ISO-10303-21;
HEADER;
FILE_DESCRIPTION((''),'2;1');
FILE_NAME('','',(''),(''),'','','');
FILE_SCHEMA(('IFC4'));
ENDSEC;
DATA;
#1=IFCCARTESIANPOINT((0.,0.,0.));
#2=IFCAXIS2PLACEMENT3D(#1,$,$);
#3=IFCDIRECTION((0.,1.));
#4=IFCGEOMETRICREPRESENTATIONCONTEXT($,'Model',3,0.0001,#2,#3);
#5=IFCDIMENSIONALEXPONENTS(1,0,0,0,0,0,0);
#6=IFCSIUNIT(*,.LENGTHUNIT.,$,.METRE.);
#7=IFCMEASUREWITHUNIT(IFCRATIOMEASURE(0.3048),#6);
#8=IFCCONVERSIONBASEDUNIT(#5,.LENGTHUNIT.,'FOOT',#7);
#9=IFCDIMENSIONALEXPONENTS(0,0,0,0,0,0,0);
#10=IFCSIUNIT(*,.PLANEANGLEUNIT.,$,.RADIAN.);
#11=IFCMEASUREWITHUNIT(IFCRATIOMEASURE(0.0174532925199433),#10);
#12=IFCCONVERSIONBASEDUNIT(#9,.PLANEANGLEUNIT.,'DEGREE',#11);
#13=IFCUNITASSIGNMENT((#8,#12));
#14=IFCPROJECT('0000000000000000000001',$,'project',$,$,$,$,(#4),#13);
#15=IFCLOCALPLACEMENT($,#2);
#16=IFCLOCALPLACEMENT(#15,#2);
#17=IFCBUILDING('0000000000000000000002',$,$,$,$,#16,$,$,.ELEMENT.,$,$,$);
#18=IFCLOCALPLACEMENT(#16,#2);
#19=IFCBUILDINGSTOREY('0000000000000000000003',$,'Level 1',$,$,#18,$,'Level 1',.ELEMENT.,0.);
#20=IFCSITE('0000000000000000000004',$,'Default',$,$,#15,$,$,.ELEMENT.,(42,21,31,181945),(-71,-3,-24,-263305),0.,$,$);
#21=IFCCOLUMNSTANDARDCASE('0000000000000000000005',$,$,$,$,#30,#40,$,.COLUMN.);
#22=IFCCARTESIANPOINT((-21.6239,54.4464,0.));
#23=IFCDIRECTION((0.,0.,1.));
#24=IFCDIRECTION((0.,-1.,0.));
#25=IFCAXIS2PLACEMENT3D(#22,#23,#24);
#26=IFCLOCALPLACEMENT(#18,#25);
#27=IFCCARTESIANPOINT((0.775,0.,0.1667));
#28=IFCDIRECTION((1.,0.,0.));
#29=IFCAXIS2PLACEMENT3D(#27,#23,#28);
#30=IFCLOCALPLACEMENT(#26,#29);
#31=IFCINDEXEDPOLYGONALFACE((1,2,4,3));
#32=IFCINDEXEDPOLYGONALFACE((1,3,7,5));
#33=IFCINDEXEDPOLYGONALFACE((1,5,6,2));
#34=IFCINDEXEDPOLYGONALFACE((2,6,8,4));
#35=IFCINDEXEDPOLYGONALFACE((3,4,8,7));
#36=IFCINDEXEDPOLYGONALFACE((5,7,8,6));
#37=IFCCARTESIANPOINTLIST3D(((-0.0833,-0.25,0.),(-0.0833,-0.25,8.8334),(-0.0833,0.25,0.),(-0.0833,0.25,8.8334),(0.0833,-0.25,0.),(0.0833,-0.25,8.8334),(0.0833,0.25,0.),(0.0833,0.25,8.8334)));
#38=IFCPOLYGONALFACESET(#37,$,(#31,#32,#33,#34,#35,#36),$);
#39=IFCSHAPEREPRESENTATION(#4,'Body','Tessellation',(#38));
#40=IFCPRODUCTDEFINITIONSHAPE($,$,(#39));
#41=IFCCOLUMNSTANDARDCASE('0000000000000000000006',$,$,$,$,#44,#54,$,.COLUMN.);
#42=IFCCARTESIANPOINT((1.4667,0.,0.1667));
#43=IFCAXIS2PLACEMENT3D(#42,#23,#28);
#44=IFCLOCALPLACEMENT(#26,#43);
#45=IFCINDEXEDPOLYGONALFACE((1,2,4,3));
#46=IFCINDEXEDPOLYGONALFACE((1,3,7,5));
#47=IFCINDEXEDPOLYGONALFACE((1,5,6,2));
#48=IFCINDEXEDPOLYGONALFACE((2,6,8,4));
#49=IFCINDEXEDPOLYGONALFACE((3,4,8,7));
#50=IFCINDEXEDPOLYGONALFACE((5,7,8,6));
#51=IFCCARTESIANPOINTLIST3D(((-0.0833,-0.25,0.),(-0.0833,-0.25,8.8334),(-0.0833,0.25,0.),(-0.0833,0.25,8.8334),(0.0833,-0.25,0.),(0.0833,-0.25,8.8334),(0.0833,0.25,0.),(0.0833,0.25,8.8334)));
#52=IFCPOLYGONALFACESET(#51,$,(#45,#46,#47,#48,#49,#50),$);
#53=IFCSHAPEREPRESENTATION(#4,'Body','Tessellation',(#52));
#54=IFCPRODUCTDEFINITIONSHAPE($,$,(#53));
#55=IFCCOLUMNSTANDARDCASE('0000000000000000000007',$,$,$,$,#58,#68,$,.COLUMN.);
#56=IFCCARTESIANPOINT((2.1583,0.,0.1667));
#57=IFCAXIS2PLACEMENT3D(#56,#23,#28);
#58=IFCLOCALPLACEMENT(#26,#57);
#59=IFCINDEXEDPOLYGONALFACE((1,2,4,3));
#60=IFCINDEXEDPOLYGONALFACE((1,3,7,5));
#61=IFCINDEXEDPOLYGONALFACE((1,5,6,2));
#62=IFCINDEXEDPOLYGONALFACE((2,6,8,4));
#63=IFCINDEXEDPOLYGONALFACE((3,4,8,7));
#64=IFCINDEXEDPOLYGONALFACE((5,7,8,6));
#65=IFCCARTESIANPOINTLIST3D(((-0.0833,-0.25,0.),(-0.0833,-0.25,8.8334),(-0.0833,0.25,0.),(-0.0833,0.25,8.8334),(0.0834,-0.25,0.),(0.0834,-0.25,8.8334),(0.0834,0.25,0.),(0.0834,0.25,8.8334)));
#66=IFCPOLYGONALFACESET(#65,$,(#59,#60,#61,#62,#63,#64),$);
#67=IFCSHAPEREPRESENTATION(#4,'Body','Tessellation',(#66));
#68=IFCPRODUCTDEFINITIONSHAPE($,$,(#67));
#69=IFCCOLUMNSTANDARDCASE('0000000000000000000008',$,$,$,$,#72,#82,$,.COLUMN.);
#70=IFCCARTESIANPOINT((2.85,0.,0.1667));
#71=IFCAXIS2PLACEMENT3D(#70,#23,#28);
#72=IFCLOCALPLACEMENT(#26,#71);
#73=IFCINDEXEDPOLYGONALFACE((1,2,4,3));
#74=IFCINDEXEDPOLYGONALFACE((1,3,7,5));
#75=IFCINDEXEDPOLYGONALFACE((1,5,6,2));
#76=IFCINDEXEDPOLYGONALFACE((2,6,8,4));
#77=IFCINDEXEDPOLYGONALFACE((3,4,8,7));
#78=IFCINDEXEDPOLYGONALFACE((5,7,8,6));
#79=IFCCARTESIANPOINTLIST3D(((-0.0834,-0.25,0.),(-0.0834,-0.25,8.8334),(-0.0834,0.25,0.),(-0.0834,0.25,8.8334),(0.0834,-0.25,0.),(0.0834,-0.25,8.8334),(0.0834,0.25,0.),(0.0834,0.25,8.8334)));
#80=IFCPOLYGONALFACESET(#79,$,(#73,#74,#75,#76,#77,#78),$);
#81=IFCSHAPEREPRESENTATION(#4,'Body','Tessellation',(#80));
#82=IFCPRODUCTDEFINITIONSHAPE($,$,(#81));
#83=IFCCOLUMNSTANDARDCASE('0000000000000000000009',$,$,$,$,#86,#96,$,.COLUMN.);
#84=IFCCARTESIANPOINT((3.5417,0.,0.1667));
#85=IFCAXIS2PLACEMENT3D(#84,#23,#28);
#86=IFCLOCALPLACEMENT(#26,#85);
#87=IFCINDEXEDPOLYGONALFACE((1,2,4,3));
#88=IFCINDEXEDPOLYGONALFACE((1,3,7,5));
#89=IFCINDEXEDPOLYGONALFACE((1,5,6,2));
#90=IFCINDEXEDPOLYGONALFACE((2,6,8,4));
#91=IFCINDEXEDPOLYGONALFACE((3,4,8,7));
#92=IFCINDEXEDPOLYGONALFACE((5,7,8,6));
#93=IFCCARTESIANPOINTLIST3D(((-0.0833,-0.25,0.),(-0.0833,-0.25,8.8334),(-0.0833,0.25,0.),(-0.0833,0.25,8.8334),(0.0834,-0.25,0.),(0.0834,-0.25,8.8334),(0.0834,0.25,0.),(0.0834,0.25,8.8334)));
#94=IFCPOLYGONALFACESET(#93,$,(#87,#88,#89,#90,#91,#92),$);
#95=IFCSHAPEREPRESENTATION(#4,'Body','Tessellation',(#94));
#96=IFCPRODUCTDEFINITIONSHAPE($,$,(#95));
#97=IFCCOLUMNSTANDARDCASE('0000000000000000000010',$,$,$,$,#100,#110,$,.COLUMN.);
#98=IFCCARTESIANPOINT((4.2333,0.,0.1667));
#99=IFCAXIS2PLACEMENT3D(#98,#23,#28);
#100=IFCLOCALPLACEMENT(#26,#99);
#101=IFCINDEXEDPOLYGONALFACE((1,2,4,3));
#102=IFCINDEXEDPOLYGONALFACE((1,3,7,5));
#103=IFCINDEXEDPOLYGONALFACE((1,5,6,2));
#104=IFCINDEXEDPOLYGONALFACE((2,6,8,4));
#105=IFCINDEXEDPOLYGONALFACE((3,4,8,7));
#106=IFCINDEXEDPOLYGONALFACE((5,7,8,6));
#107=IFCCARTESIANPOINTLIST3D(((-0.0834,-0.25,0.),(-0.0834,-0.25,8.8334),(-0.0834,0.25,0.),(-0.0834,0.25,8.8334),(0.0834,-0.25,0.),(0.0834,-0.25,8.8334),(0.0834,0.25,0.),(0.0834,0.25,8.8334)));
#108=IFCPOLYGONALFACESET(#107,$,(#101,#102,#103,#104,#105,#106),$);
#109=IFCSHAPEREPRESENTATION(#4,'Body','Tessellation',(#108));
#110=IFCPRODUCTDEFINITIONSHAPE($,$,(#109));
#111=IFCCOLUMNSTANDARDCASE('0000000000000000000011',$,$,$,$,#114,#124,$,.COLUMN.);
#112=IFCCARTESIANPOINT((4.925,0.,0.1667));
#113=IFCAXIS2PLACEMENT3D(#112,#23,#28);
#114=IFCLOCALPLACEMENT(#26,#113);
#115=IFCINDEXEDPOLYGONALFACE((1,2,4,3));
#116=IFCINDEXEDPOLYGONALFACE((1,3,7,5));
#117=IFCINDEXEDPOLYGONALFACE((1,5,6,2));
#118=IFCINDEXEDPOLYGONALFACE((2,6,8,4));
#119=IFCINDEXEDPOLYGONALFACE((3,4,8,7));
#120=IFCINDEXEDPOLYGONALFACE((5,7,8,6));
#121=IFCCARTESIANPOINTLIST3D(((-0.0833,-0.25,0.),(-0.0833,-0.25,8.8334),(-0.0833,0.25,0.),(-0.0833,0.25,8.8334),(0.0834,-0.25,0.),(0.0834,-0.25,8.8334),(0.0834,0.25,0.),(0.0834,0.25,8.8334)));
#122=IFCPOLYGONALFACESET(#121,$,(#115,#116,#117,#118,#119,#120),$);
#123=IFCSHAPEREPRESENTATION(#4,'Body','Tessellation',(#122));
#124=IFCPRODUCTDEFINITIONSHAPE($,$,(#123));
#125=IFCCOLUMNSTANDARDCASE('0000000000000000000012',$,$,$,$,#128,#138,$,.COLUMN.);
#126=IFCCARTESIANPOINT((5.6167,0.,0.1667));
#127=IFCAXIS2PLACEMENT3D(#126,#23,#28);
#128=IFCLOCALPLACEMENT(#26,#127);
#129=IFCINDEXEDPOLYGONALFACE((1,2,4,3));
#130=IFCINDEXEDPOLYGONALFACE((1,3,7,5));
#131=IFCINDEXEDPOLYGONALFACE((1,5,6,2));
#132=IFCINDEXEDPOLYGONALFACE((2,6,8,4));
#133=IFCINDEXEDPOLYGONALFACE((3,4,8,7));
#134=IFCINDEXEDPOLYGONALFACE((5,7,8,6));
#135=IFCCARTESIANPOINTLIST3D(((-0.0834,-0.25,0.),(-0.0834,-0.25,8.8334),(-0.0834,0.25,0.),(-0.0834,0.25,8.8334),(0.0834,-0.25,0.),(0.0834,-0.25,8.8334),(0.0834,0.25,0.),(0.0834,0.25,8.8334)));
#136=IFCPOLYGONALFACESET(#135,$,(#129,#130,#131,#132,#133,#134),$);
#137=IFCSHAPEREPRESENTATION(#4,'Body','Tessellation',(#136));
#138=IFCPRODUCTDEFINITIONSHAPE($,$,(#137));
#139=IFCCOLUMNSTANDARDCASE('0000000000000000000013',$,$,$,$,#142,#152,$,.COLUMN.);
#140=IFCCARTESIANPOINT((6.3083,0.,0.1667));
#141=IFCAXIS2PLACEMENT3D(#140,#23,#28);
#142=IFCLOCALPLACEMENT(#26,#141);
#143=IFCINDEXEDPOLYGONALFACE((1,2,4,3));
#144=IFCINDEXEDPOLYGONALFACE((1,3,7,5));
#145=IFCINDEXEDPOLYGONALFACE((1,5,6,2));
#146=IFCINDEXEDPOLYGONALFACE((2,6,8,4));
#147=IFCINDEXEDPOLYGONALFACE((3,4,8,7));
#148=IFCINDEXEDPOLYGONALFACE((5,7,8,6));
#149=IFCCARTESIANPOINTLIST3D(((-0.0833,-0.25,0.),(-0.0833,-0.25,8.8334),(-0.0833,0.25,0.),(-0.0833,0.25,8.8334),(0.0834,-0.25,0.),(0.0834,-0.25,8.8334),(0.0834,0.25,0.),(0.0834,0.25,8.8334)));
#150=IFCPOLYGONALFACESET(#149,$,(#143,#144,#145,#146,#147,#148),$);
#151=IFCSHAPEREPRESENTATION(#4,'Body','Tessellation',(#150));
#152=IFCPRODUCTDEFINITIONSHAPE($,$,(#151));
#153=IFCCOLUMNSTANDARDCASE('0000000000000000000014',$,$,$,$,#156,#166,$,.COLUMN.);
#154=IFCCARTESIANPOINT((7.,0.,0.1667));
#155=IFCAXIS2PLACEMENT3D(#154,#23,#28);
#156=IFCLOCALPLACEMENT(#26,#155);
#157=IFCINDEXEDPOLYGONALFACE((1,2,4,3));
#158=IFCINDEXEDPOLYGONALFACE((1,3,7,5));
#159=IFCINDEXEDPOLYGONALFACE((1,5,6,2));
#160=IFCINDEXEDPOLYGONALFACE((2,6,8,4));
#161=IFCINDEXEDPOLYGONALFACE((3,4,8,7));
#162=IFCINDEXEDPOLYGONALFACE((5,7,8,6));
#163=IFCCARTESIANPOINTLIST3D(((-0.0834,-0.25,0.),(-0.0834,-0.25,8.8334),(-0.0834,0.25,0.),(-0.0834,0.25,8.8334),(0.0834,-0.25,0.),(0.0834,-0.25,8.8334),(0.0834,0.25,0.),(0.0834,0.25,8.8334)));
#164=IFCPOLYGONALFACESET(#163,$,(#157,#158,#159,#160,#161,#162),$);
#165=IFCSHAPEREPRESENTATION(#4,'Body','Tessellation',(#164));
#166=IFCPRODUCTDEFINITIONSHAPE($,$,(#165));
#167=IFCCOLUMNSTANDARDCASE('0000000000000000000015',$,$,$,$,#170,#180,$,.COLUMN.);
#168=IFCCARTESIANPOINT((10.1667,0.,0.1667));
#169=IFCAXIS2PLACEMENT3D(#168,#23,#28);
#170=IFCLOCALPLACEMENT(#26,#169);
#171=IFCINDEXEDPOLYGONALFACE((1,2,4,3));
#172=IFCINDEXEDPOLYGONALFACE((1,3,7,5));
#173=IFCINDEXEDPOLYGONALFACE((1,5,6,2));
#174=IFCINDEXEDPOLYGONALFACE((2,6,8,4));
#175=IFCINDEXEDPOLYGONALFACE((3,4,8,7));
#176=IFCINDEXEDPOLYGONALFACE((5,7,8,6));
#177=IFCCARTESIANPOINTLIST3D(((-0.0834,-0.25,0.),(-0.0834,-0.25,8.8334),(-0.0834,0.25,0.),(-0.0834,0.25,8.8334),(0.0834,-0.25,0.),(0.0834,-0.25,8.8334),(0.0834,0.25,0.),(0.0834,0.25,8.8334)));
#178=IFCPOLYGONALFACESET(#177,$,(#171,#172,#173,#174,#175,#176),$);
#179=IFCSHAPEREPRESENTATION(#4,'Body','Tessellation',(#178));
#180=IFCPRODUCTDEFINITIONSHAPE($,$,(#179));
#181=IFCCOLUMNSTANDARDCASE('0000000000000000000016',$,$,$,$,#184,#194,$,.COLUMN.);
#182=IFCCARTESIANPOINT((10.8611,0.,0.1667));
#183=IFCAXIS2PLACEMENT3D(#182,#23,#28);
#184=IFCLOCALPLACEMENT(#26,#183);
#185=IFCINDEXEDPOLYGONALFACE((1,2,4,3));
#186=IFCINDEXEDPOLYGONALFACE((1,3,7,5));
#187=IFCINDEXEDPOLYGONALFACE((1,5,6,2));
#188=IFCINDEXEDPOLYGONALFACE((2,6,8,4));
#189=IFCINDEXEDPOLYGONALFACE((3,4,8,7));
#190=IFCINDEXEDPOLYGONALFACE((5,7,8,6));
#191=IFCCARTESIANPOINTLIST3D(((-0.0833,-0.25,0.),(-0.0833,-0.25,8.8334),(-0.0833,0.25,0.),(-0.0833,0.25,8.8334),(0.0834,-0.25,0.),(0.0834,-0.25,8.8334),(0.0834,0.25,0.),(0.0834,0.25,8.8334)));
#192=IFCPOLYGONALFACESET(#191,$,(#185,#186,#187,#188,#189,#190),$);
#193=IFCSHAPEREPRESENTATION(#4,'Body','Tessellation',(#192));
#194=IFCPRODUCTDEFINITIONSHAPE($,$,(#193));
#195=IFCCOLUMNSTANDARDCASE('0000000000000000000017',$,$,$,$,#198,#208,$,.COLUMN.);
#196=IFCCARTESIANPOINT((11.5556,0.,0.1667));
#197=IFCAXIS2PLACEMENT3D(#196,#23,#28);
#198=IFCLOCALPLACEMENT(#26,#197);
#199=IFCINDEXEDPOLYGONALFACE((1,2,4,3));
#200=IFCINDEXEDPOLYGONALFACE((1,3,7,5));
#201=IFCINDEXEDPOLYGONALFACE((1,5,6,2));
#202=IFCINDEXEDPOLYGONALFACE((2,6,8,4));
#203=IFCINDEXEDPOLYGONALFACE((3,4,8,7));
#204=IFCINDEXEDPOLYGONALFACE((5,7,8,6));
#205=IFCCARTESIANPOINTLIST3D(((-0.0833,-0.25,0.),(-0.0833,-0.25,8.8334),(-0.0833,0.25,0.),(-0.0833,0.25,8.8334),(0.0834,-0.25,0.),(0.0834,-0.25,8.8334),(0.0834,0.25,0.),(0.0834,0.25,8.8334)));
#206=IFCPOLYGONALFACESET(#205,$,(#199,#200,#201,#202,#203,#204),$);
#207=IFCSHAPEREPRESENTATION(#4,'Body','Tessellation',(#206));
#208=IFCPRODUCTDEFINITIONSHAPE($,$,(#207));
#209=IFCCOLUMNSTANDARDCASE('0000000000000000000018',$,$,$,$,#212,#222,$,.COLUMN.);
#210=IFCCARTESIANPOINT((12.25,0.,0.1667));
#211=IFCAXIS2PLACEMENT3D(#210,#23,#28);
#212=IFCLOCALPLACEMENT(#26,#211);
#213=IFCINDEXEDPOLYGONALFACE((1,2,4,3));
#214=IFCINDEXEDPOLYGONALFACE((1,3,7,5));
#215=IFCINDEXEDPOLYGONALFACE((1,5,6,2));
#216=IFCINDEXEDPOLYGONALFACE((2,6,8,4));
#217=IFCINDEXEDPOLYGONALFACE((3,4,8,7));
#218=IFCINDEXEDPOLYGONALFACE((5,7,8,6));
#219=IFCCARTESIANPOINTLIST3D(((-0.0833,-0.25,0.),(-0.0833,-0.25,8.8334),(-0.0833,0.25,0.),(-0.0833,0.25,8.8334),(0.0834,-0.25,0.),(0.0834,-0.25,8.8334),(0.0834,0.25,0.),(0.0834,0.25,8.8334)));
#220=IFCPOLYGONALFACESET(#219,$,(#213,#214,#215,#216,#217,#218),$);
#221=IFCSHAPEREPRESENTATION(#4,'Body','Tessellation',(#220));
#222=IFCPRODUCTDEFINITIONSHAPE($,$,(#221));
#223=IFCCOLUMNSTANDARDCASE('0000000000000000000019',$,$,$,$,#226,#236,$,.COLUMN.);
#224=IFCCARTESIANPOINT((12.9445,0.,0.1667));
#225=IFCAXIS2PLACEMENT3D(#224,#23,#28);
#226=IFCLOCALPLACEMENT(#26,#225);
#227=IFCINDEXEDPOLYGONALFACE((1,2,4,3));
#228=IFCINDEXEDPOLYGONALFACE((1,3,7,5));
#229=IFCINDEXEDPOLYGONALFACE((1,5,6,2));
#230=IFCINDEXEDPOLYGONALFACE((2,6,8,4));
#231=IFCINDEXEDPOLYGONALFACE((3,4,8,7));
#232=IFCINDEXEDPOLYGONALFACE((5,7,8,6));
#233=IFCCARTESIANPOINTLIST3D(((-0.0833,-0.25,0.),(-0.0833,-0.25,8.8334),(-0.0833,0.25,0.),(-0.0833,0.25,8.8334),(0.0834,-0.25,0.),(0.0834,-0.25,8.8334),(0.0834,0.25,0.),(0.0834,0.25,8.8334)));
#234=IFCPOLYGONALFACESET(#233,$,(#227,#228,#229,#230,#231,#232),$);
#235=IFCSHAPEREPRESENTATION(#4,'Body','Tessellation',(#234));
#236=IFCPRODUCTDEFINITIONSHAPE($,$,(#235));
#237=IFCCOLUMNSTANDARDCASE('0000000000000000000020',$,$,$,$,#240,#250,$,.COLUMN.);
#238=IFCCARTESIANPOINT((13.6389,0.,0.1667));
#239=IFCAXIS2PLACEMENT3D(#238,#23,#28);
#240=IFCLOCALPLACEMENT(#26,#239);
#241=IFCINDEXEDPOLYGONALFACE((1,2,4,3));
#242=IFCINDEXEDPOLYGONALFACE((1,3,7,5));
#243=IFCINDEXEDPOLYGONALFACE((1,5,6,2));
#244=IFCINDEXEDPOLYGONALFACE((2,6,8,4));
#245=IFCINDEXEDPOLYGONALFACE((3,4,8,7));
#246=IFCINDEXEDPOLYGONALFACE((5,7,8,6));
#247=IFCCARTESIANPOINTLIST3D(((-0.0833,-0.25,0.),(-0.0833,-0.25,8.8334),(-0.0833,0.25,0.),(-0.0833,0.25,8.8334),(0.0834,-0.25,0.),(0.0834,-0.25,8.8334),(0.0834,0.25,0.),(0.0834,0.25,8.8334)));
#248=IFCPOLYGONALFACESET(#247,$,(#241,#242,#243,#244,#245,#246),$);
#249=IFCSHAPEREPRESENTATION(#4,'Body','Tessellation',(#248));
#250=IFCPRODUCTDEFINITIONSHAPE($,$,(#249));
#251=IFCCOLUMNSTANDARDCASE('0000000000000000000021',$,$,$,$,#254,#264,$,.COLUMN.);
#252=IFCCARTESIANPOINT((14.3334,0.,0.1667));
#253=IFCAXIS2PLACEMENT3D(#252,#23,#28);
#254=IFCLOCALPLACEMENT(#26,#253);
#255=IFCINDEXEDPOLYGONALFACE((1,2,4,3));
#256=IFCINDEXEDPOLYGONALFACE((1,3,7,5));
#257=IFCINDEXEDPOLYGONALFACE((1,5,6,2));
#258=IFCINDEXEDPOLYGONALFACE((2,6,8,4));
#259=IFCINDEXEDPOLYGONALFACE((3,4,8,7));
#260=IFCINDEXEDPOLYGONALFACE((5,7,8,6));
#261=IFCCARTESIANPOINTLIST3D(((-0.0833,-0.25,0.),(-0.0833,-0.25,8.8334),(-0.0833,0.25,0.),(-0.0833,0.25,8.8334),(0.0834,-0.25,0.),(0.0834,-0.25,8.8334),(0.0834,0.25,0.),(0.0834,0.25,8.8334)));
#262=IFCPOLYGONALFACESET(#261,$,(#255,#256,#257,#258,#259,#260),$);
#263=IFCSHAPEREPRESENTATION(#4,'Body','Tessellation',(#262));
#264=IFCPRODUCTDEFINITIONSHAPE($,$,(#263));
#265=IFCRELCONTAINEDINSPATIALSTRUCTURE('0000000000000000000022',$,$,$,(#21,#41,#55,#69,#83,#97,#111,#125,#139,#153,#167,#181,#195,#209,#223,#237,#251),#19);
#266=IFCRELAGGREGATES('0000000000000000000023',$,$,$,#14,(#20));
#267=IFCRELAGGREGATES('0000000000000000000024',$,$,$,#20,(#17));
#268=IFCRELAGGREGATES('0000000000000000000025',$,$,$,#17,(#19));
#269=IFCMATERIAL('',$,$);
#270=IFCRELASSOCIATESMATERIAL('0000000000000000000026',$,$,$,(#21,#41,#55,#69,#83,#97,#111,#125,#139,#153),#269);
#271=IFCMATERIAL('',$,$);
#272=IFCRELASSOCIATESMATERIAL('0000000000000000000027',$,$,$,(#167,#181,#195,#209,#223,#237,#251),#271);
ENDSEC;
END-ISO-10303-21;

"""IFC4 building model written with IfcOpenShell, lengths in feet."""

from ifc_helpers import new_model, entity, si_unit, converted_unit, direction, frame, origin, place, context, project, spatial, rectangle, extrude, material, element, save


model = new_model("IFC4")

# Units and contexts
model_context = context("Model", 3, precision=0.0001, world=origin(), true_north=direction((0.0, 1.0)))
ifc_project = project(units=[converted_unit("LENGTHUNIT", "FOOT", entity("IfcRatioMeasure", 0.3048), si_unit("LENGTHUNIT", "METRE"), dimensions=[1, 0, 0, 0, 0, 0, 0]), converted_unit("PLANEANGLEUNIT", "DEGREE", entity("IfcRatioMeasure", 0.0174532925199433), si_unit("PLANEANGLEUNIT", "RADIAN"), dimensions=[0, 0, 0, 0, 0, 0, 0])], contexts=[model_context])

# Site, building, storey
site_placement = place(None, origin())
site = spatial("IfcSite", under=ifc_project, at=site_placement, Name="Default", CompositionType="ELEMENT", RefLatitude=(42, 21, 31, 181945), RefLongitude=(-71, -3, -24, -263305), RefElevation=0.0)
building_placement = place(site_placement, origin())
building = spatial("IfcBuilding", under=site, at=building_placement, CompositionType="ELEMENT")
storey_placement = place(building_placement, origin())
storey = spatial("IfcBuildingStorey", under=building, at=storey_placement, Name="Level 1", LongName="Level 1", CompositionType="ELEMENT", Elevation=0.0)

# Columns
ifc_material_1 = material(Name="")
placement_1 = place(storey_placement, frame((-21.6239, 54.4464, 0.0), z_axis=(0.0, 0.0, 1.0), x_axis=(0.0, -1.0, 0.0)))
for number, where, z_axis, x_axis in (
    (1, (0.775, 0.0, 0.1667), (0.0, 0.0, 1.0), (1.0, 0.0, 0.0)),
    (2, (1.4667, 0.0, 0.1667), (0.0, 0.0, 1.0), (1.0, 0.0, 0.0)),
    (3, (2.1583, 0.0, 0.1667), (0.0, 0.0, 1.0), (1.0, 0.0, 0.0)),
    (4, (2.85, 0.0, 0.1667), (0.0, 0.0, 1.0), (1.0, 0.0, 0.0)),
    (5, (3.5417, 0.0, 0.1667), (0.0, 0.0, 1.0), (1.0, 0.0, 0.0)),
    (6, (4.2333, 0.0, 0.1667), (0.0, 0.0, 1.0), (1.0, 0.0, 0.0)),
    (7, (4.925, 0.0, 0.1667), (0.0, 0.0, 1.0), (1.0, 0.0, 0.0)),
    (8, (5.6167, 0.0, 0.1667), (0.0, 0.0, 1.0), (1.0, 0.0, 0.0)),
    (9, (6.3083, 0.0, 0.1667), (0.0, 0.0, 1.0), (1.0, 0.0, 0.0)),
    (10, (7.0, 0.0, 0.1667), (0.0, 0.0, 1.0), (1.0, 0.0, 0.0)),
):
    element("IfcColumnStandardCase", number, at=place(placement_1, frame(where, z_axis=z_axis, x_axis=x_axis)), inside=storey, material=ifc_material_1, PredefinedType="COLUMN", context=model_context, shape_type="SweptSolid", body=[
        extrude(rectangle(XDim=0.1667, YDim=0.5), origin(), (0.0, 0.0, 1.0), 8.8334),
    ])
ifc_material_2 = material(Name="")
for number, where, z_axis, x_axis in (
    (11, (10.1667, 0.0, 0.1667), (0.0, 0.0, 1.0), (1.0, 0.0, 0.0)),
    (12, (10.8611, 0.0, 0.1667), (0.0, 0.0, 1.0), (1.0, 0.0, 0.0)),
    (13, (11.5556, 0.0, 0.1667), (0.0, 0.0, 1.0), (1.0, 0.0, 0.0)),
    (14, (12.25, 0.0, 0.1667), (0.0, 0.0, 1.0), (1.0, 0.0, 0.0)),
    (15, (12.9445, 0.0, 0.1667), (0.0, 0.0, 1.0), (1.0, 0.0, 0.0)),
    (16, (13.6389, 0.0, 0.1667), (0.0, 0.0, 1.0), (1.0, 0.0, 0.0)),
    (17, (14.3334, 0.0, 0.1667), (0.0, 0.0, 1.0), (1.0, 0.0, 0.0)),
):
    element("IfcColumnStandardCase", number, at=place(placement_1, frame(where, z_axis=z_axis, x_axis=x_axis)), inside=storey, material=ifc_material_2, PredefinedType="COLUMN", context=model_context, shape_type="SweptSolid", body=[
        extrude(rectangle(XDim=0.1667, YDim=0.5), origin(), (0.0, 0.0, 1.0), 8.8334),
    ])

save(model, "model.ifc")
